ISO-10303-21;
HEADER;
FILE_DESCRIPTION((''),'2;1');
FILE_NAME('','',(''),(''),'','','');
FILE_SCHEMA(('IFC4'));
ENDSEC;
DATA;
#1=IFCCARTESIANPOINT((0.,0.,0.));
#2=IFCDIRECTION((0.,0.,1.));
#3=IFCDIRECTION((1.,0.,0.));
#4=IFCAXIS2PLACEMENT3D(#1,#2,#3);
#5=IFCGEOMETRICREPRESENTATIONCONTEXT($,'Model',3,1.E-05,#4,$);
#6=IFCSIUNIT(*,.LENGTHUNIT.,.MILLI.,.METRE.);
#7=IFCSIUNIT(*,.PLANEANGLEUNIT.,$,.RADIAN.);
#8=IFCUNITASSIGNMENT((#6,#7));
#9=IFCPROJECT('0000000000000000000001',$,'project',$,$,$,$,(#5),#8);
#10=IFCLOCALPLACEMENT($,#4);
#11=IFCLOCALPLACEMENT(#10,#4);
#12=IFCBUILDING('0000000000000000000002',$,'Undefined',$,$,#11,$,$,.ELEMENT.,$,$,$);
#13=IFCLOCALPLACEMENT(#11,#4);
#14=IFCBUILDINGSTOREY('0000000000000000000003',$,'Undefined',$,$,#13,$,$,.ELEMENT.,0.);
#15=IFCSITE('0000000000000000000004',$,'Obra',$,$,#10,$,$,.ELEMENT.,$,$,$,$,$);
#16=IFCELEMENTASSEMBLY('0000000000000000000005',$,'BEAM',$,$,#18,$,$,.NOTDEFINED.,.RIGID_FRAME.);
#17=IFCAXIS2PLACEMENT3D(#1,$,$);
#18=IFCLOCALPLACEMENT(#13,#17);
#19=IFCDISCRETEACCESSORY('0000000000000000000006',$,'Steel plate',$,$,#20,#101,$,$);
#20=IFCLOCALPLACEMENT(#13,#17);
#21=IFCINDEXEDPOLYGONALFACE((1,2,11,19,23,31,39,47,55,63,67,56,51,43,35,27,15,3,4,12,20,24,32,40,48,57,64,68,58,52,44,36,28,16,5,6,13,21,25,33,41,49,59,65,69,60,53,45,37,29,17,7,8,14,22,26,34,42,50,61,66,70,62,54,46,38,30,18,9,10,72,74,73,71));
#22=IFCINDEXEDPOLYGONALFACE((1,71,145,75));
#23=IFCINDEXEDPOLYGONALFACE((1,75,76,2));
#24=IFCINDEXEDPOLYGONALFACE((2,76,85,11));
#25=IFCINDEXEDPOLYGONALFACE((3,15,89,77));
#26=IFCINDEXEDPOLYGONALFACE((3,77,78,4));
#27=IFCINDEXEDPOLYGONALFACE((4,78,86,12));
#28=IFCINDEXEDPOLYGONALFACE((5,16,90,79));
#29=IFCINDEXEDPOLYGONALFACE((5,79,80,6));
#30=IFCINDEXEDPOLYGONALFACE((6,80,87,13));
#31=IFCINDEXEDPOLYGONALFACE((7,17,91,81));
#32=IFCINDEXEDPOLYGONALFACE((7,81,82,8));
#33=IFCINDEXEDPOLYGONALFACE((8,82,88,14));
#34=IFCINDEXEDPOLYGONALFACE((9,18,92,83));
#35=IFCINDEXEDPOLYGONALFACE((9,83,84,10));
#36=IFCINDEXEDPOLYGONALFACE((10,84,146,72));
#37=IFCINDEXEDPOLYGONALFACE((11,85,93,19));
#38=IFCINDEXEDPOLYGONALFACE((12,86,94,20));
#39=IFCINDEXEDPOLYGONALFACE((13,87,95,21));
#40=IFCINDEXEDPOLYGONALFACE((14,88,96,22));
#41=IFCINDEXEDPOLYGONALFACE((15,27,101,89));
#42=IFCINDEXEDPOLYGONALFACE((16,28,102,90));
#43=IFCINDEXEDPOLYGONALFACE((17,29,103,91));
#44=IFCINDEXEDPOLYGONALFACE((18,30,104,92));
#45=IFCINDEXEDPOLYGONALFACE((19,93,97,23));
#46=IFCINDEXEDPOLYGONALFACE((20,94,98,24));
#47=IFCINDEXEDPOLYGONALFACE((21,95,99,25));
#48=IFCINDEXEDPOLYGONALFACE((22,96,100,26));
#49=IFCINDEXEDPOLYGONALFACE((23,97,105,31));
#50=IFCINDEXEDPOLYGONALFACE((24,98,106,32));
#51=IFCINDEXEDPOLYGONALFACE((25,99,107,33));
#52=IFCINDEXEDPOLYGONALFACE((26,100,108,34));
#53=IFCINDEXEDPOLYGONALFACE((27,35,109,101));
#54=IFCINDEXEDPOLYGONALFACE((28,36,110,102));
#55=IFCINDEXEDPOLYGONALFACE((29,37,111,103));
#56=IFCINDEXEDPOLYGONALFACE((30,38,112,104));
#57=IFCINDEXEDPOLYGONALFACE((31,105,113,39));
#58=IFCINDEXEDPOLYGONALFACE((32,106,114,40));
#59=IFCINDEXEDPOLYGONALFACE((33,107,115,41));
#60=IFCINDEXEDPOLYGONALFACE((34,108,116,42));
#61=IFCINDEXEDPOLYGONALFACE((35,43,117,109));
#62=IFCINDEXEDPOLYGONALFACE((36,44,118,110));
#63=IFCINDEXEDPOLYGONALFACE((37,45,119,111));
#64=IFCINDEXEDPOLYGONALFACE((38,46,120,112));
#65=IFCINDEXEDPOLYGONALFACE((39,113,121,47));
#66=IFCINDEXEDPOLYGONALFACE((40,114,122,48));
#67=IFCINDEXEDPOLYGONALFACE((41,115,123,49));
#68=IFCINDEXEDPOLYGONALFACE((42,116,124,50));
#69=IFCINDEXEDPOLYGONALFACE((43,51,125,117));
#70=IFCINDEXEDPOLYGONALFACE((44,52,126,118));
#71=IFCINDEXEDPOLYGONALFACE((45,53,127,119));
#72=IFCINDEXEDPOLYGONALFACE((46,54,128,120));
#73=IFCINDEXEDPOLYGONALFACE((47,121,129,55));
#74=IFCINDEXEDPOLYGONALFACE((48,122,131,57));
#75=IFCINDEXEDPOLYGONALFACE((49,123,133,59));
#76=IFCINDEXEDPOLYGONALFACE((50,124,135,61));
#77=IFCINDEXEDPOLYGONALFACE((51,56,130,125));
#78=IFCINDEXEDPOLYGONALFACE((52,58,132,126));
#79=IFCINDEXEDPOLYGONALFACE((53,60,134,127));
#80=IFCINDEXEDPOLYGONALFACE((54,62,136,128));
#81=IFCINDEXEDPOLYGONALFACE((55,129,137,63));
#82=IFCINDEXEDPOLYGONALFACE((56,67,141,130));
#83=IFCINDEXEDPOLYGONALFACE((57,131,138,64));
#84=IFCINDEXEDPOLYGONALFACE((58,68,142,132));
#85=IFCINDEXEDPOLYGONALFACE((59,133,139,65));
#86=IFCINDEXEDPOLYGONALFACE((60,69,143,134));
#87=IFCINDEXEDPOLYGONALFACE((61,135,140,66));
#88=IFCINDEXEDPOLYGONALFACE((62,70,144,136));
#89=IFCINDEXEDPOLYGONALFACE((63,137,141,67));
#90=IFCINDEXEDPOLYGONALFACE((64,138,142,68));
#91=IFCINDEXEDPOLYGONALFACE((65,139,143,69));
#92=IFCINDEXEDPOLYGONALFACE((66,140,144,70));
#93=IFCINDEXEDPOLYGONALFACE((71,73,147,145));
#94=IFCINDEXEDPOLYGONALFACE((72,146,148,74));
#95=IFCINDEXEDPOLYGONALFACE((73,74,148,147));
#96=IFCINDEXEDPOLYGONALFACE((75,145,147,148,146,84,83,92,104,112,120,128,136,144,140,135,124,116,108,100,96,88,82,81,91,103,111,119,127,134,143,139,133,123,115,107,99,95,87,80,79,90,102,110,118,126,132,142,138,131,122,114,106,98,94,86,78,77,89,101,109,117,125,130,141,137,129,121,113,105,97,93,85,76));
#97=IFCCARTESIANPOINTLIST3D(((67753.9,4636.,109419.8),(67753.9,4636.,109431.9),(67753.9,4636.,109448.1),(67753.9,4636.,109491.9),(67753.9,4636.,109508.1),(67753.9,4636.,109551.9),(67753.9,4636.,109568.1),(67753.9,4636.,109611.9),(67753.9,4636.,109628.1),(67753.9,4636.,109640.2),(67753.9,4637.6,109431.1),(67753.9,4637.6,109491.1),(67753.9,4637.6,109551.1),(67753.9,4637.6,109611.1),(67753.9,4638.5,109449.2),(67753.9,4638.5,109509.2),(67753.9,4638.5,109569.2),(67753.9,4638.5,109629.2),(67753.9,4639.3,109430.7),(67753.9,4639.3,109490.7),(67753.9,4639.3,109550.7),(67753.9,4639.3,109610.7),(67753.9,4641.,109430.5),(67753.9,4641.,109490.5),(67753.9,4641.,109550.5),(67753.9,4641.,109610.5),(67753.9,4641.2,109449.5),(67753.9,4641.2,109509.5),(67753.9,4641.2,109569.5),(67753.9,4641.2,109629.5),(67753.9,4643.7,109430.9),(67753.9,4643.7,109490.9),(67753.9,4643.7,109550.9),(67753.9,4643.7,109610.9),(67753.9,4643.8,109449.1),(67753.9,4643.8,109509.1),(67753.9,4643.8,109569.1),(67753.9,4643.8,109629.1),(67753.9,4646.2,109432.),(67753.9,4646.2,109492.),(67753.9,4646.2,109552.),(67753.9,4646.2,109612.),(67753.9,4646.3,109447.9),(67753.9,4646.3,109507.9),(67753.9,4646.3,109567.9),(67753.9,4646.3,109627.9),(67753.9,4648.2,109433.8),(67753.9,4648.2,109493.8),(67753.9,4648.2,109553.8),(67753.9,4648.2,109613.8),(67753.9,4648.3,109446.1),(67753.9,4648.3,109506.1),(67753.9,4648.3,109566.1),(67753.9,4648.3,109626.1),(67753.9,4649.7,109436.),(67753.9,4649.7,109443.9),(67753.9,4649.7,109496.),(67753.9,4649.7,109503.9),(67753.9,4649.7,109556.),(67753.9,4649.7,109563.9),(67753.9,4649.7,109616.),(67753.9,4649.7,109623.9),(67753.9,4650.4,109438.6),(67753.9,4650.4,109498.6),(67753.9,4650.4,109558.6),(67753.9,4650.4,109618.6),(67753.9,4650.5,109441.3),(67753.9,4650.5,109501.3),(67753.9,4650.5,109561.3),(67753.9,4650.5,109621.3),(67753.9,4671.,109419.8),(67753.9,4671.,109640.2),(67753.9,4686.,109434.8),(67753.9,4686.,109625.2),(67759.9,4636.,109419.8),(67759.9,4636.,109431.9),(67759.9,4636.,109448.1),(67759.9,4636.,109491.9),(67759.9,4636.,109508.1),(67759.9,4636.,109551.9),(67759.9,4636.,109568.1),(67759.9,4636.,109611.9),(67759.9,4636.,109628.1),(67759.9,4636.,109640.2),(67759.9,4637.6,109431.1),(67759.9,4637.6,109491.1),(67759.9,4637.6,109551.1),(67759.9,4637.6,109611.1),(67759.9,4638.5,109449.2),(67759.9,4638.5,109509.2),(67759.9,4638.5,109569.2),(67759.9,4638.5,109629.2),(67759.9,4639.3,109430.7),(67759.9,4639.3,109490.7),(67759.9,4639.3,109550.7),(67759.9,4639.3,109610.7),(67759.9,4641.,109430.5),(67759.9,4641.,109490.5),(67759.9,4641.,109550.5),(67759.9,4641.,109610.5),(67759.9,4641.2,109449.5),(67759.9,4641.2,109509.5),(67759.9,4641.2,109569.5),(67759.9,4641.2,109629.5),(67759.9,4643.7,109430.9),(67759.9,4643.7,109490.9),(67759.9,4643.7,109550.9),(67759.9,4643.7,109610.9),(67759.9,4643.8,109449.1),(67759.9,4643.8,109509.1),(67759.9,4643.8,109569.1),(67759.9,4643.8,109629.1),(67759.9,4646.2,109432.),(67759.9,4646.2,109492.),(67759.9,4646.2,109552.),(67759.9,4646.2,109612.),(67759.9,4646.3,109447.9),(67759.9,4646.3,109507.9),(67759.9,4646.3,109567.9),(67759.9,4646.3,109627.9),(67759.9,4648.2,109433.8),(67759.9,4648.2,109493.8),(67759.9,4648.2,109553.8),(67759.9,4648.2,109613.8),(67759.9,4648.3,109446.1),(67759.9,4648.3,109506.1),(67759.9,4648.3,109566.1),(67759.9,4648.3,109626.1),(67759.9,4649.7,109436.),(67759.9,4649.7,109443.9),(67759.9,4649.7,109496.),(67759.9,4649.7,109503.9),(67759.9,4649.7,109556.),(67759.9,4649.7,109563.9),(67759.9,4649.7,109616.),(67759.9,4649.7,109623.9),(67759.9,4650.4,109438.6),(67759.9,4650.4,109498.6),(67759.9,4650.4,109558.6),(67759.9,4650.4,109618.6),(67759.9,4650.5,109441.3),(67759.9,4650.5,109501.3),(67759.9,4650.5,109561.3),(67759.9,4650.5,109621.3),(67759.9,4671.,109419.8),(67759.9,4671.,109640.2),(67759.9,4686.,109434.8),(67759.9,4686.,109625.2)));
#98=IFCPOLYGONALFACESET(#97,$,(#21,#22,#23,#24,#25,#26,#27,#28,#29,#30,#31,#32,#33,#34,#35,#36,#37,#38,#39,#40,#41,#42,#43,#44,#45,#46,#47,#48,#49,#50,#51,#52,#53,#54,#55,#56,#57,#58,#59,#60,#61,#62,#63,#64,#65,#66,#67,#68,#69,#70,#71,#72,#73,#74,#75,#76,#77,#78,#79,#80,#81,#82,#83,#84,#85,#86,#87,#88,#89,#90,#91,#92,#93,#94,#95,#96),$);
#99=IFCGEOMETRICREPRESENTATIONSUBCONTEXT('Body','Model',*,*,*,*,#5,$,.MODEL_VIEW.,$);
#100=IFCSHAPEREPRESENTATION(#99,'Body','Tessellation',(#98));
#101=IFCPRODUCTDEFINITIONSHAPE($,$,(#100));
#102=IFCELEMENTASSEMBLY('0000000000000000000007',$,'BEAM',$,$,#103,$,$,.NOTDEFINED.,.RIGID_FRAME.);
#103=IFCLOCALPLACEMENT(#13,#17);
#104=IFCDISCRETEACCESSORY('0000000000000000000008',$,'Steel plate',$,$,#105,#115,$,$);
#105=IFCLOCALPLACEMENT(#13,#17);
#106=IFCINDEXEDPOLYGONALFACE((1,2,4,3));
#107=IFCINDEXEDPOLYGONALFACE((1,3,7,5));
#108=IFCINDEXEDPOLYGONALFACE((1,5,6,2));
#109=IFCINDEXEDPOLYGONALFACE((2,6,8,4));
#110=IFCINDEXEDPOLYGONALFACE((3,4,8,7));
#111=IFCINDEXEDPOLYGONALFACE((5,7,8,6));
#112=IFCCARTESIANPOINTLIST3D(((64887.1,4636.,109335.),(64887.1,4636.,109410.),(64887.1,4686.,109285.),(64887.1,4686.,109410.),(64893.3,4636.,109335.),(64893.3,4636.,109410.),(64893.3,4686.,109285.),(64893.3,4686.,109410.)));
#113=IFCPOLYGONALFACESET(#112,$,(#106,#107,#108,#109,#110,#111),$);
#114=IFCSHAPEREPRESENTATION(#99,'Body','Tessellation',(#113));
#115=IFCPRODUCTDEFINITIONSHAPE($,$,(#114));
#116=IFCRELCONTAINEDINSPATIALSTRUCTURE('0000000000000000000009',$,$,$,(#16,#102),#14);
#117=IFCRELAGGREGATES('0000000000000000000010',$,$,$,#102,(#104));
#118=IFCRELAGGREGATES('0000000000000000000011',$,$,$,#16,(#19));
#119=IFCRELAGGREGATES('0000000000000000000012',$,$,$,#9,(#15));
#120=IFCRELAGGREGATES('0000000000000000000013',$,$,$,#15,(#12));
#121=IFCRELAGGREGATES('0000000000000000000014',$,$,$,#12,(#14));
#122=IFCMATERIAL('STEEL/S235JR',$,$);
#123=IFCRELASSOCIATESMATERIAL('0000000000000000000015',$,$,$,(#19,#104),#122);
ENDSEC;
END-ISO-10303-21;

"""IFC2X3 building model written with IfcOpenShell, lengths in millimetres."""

from ifc_helpers import new_model, si_unit, frame, origin_with_axes, origin_2d_with_axis, place, context, subcontext, project, spatial, polyline, circle, outline, extrude, source, transform, mapped, material, element, aggregate, save


model = new_model("IFC2X3")

# Units and contexts
model_context = context("Model", 3, precision=1e-05, world=origin_with_axes())
body_context = subcontext(model_context, "Body", "Model", "MODEL_VIEW")
ifc_project = project(units=[si_unit("LENGTHUNIT", "METRE", prefix="MILLI"), si_unit("PLANEANGLEUNIT", "RADIAN")], contexts=[model_context])

# Site, building, storey
site_placement = place(None, origin_with_axes())
site = spatial("IfcSite", under=ifc_project, at=site_placement, Name="Obra", CompositionType="ELEMENT")
building_placement = place(site_placement, origin_with_axes())
building = spatial("IfcBuilding", under=site, at=building_placement, Name="Undefined", CompositionType="ELEMENT")
storey_placement = place(building_placement, origin_with_axes())
storey = spatial("IfcBuildingStorey", under=building, at=storey_placement, Name="Undefined", CompositionType="ELEMENT", Elevation=0.0)

# Shared definitions
ifc_material_1 = material(Name="STEEL/S235JR")

# Shared definitions
shared_shape_1 = source(origin_with_axes(), body_context, "Body", "SweptSolid", [
    extrude(circle(Radius=9.5, at=origin_2d_with_axis()), frame((0.0, -9.2, 0.0), z_axis=(0.0, 1.0, 0.0), x_axis=(1.0, 0.0, 0.0)), (0.0, 0.0, 1.0), 6.2),
])

# Element assembly
assembly_1_placement = place(storey_placement, origin_with_axes())
assembly_1 = element("IfcElementAssembly", 1, at=assembly_1_placement, inside=storey, Name="BEAM", AssemblyPlace="NOTDEFINED", PredefinedType="RIGID_FRAME")

# Discrete accessory, opening
discrete_accessory_1_placement = place(assembly_1_placement, frame((67756.9, 4636.0, 109419.8), z_axis=(1.0, 0.0, 0.0), x_axis=(0.0, 1.0, 0.0)))
discrete_accessory_1 = element("IfcDiscreteAccessory", 2, at=discrete_accessory_1_placement, material=ifc_material_1, Name="Steel plate", context=body_context, shape_type="SweptSolid", body=[
    extrude(outline(polyline([(0.0, 0.0), (35.0, 0.0), (50.0, 15.0), (50.0, 205.4), (35.0, 220.4), (0.0, 220.4), (0.0, 0.0)])), frame((0.0, 0.0, -3.0), z_axis=(0.0, 0.0, 1.0), x_axis=(1.0, 0.0, 0.0)), (0.0, 0.0, 1.0), 6.0),
])
opening_1_placement = place(assembly_1_placement, frame((67763.0, 4676.0, 109650.0), z_axis=(0.0, -1.0, 0.0), x_axis=(0.0, 0.0, -1.0)))
element("IfcOpeningElement", 3, at=opening_1_placement, cuts=discrete_accessory_1, ObjectType="Opening", context=body_context, shape_type="MappedRepresentation", body=[
    mapped(shared_shape_1, transform((30.0, 0.0, 35.0))),
    mapped(shared_shape_1, transform((90.0, 0.0, 35.0))),
    mapped(shared_shape_1, transform((150.0, 0.0, 35.0))),
    mapped(shared_shape_1, transform((210.0, 0.0, 35.0))),
])

# Element assembly, discrete accessory
assembly_2_placement = place(storey_placement, origin_with_axes())
assembly_2 = element("IfcElementAssembly", 4, at=assembly_2_placement, inside=storey, Name="BEAM", AssemblyPlace="NOTDEFINED", PredefinedType="RIGID_FRAME")
discrete_accessory_2_placement = place(assembly_2_placement, frame((64890.2, 4686.0, 109410.0), z_axis=(-1.0, 0.0, 0.0), x_axis=(0.0, 0.0, -1.0)))
discrete_accessory_2 = element("IfcDiscreteAccessory", 5, at=discrete_accessory_2_placement, material=ifc_material_1, Name="Steel plate", context=body_context, shape_type="SweptSolid", body=[
    extrude(outline(polyline([(0.0, 0.0), (150.0, 0.0), (150.0, -25.0), (75.0, 50.0), (0.0, 50.0), (0.0, 0.0)])), frame((0.0, 0.0, -3.1), z_axis=(0.0, 0.0, 1.0), x_axis=(1.0, 0.0, 0.0)), (0.0, 0.0, 1.0), 6.2),
])
aggregate(assembly_2, [discrete_accessory_2])

aggregate(assembly_1, [discrete_accessory_1])

save(model, "model.ifc")
